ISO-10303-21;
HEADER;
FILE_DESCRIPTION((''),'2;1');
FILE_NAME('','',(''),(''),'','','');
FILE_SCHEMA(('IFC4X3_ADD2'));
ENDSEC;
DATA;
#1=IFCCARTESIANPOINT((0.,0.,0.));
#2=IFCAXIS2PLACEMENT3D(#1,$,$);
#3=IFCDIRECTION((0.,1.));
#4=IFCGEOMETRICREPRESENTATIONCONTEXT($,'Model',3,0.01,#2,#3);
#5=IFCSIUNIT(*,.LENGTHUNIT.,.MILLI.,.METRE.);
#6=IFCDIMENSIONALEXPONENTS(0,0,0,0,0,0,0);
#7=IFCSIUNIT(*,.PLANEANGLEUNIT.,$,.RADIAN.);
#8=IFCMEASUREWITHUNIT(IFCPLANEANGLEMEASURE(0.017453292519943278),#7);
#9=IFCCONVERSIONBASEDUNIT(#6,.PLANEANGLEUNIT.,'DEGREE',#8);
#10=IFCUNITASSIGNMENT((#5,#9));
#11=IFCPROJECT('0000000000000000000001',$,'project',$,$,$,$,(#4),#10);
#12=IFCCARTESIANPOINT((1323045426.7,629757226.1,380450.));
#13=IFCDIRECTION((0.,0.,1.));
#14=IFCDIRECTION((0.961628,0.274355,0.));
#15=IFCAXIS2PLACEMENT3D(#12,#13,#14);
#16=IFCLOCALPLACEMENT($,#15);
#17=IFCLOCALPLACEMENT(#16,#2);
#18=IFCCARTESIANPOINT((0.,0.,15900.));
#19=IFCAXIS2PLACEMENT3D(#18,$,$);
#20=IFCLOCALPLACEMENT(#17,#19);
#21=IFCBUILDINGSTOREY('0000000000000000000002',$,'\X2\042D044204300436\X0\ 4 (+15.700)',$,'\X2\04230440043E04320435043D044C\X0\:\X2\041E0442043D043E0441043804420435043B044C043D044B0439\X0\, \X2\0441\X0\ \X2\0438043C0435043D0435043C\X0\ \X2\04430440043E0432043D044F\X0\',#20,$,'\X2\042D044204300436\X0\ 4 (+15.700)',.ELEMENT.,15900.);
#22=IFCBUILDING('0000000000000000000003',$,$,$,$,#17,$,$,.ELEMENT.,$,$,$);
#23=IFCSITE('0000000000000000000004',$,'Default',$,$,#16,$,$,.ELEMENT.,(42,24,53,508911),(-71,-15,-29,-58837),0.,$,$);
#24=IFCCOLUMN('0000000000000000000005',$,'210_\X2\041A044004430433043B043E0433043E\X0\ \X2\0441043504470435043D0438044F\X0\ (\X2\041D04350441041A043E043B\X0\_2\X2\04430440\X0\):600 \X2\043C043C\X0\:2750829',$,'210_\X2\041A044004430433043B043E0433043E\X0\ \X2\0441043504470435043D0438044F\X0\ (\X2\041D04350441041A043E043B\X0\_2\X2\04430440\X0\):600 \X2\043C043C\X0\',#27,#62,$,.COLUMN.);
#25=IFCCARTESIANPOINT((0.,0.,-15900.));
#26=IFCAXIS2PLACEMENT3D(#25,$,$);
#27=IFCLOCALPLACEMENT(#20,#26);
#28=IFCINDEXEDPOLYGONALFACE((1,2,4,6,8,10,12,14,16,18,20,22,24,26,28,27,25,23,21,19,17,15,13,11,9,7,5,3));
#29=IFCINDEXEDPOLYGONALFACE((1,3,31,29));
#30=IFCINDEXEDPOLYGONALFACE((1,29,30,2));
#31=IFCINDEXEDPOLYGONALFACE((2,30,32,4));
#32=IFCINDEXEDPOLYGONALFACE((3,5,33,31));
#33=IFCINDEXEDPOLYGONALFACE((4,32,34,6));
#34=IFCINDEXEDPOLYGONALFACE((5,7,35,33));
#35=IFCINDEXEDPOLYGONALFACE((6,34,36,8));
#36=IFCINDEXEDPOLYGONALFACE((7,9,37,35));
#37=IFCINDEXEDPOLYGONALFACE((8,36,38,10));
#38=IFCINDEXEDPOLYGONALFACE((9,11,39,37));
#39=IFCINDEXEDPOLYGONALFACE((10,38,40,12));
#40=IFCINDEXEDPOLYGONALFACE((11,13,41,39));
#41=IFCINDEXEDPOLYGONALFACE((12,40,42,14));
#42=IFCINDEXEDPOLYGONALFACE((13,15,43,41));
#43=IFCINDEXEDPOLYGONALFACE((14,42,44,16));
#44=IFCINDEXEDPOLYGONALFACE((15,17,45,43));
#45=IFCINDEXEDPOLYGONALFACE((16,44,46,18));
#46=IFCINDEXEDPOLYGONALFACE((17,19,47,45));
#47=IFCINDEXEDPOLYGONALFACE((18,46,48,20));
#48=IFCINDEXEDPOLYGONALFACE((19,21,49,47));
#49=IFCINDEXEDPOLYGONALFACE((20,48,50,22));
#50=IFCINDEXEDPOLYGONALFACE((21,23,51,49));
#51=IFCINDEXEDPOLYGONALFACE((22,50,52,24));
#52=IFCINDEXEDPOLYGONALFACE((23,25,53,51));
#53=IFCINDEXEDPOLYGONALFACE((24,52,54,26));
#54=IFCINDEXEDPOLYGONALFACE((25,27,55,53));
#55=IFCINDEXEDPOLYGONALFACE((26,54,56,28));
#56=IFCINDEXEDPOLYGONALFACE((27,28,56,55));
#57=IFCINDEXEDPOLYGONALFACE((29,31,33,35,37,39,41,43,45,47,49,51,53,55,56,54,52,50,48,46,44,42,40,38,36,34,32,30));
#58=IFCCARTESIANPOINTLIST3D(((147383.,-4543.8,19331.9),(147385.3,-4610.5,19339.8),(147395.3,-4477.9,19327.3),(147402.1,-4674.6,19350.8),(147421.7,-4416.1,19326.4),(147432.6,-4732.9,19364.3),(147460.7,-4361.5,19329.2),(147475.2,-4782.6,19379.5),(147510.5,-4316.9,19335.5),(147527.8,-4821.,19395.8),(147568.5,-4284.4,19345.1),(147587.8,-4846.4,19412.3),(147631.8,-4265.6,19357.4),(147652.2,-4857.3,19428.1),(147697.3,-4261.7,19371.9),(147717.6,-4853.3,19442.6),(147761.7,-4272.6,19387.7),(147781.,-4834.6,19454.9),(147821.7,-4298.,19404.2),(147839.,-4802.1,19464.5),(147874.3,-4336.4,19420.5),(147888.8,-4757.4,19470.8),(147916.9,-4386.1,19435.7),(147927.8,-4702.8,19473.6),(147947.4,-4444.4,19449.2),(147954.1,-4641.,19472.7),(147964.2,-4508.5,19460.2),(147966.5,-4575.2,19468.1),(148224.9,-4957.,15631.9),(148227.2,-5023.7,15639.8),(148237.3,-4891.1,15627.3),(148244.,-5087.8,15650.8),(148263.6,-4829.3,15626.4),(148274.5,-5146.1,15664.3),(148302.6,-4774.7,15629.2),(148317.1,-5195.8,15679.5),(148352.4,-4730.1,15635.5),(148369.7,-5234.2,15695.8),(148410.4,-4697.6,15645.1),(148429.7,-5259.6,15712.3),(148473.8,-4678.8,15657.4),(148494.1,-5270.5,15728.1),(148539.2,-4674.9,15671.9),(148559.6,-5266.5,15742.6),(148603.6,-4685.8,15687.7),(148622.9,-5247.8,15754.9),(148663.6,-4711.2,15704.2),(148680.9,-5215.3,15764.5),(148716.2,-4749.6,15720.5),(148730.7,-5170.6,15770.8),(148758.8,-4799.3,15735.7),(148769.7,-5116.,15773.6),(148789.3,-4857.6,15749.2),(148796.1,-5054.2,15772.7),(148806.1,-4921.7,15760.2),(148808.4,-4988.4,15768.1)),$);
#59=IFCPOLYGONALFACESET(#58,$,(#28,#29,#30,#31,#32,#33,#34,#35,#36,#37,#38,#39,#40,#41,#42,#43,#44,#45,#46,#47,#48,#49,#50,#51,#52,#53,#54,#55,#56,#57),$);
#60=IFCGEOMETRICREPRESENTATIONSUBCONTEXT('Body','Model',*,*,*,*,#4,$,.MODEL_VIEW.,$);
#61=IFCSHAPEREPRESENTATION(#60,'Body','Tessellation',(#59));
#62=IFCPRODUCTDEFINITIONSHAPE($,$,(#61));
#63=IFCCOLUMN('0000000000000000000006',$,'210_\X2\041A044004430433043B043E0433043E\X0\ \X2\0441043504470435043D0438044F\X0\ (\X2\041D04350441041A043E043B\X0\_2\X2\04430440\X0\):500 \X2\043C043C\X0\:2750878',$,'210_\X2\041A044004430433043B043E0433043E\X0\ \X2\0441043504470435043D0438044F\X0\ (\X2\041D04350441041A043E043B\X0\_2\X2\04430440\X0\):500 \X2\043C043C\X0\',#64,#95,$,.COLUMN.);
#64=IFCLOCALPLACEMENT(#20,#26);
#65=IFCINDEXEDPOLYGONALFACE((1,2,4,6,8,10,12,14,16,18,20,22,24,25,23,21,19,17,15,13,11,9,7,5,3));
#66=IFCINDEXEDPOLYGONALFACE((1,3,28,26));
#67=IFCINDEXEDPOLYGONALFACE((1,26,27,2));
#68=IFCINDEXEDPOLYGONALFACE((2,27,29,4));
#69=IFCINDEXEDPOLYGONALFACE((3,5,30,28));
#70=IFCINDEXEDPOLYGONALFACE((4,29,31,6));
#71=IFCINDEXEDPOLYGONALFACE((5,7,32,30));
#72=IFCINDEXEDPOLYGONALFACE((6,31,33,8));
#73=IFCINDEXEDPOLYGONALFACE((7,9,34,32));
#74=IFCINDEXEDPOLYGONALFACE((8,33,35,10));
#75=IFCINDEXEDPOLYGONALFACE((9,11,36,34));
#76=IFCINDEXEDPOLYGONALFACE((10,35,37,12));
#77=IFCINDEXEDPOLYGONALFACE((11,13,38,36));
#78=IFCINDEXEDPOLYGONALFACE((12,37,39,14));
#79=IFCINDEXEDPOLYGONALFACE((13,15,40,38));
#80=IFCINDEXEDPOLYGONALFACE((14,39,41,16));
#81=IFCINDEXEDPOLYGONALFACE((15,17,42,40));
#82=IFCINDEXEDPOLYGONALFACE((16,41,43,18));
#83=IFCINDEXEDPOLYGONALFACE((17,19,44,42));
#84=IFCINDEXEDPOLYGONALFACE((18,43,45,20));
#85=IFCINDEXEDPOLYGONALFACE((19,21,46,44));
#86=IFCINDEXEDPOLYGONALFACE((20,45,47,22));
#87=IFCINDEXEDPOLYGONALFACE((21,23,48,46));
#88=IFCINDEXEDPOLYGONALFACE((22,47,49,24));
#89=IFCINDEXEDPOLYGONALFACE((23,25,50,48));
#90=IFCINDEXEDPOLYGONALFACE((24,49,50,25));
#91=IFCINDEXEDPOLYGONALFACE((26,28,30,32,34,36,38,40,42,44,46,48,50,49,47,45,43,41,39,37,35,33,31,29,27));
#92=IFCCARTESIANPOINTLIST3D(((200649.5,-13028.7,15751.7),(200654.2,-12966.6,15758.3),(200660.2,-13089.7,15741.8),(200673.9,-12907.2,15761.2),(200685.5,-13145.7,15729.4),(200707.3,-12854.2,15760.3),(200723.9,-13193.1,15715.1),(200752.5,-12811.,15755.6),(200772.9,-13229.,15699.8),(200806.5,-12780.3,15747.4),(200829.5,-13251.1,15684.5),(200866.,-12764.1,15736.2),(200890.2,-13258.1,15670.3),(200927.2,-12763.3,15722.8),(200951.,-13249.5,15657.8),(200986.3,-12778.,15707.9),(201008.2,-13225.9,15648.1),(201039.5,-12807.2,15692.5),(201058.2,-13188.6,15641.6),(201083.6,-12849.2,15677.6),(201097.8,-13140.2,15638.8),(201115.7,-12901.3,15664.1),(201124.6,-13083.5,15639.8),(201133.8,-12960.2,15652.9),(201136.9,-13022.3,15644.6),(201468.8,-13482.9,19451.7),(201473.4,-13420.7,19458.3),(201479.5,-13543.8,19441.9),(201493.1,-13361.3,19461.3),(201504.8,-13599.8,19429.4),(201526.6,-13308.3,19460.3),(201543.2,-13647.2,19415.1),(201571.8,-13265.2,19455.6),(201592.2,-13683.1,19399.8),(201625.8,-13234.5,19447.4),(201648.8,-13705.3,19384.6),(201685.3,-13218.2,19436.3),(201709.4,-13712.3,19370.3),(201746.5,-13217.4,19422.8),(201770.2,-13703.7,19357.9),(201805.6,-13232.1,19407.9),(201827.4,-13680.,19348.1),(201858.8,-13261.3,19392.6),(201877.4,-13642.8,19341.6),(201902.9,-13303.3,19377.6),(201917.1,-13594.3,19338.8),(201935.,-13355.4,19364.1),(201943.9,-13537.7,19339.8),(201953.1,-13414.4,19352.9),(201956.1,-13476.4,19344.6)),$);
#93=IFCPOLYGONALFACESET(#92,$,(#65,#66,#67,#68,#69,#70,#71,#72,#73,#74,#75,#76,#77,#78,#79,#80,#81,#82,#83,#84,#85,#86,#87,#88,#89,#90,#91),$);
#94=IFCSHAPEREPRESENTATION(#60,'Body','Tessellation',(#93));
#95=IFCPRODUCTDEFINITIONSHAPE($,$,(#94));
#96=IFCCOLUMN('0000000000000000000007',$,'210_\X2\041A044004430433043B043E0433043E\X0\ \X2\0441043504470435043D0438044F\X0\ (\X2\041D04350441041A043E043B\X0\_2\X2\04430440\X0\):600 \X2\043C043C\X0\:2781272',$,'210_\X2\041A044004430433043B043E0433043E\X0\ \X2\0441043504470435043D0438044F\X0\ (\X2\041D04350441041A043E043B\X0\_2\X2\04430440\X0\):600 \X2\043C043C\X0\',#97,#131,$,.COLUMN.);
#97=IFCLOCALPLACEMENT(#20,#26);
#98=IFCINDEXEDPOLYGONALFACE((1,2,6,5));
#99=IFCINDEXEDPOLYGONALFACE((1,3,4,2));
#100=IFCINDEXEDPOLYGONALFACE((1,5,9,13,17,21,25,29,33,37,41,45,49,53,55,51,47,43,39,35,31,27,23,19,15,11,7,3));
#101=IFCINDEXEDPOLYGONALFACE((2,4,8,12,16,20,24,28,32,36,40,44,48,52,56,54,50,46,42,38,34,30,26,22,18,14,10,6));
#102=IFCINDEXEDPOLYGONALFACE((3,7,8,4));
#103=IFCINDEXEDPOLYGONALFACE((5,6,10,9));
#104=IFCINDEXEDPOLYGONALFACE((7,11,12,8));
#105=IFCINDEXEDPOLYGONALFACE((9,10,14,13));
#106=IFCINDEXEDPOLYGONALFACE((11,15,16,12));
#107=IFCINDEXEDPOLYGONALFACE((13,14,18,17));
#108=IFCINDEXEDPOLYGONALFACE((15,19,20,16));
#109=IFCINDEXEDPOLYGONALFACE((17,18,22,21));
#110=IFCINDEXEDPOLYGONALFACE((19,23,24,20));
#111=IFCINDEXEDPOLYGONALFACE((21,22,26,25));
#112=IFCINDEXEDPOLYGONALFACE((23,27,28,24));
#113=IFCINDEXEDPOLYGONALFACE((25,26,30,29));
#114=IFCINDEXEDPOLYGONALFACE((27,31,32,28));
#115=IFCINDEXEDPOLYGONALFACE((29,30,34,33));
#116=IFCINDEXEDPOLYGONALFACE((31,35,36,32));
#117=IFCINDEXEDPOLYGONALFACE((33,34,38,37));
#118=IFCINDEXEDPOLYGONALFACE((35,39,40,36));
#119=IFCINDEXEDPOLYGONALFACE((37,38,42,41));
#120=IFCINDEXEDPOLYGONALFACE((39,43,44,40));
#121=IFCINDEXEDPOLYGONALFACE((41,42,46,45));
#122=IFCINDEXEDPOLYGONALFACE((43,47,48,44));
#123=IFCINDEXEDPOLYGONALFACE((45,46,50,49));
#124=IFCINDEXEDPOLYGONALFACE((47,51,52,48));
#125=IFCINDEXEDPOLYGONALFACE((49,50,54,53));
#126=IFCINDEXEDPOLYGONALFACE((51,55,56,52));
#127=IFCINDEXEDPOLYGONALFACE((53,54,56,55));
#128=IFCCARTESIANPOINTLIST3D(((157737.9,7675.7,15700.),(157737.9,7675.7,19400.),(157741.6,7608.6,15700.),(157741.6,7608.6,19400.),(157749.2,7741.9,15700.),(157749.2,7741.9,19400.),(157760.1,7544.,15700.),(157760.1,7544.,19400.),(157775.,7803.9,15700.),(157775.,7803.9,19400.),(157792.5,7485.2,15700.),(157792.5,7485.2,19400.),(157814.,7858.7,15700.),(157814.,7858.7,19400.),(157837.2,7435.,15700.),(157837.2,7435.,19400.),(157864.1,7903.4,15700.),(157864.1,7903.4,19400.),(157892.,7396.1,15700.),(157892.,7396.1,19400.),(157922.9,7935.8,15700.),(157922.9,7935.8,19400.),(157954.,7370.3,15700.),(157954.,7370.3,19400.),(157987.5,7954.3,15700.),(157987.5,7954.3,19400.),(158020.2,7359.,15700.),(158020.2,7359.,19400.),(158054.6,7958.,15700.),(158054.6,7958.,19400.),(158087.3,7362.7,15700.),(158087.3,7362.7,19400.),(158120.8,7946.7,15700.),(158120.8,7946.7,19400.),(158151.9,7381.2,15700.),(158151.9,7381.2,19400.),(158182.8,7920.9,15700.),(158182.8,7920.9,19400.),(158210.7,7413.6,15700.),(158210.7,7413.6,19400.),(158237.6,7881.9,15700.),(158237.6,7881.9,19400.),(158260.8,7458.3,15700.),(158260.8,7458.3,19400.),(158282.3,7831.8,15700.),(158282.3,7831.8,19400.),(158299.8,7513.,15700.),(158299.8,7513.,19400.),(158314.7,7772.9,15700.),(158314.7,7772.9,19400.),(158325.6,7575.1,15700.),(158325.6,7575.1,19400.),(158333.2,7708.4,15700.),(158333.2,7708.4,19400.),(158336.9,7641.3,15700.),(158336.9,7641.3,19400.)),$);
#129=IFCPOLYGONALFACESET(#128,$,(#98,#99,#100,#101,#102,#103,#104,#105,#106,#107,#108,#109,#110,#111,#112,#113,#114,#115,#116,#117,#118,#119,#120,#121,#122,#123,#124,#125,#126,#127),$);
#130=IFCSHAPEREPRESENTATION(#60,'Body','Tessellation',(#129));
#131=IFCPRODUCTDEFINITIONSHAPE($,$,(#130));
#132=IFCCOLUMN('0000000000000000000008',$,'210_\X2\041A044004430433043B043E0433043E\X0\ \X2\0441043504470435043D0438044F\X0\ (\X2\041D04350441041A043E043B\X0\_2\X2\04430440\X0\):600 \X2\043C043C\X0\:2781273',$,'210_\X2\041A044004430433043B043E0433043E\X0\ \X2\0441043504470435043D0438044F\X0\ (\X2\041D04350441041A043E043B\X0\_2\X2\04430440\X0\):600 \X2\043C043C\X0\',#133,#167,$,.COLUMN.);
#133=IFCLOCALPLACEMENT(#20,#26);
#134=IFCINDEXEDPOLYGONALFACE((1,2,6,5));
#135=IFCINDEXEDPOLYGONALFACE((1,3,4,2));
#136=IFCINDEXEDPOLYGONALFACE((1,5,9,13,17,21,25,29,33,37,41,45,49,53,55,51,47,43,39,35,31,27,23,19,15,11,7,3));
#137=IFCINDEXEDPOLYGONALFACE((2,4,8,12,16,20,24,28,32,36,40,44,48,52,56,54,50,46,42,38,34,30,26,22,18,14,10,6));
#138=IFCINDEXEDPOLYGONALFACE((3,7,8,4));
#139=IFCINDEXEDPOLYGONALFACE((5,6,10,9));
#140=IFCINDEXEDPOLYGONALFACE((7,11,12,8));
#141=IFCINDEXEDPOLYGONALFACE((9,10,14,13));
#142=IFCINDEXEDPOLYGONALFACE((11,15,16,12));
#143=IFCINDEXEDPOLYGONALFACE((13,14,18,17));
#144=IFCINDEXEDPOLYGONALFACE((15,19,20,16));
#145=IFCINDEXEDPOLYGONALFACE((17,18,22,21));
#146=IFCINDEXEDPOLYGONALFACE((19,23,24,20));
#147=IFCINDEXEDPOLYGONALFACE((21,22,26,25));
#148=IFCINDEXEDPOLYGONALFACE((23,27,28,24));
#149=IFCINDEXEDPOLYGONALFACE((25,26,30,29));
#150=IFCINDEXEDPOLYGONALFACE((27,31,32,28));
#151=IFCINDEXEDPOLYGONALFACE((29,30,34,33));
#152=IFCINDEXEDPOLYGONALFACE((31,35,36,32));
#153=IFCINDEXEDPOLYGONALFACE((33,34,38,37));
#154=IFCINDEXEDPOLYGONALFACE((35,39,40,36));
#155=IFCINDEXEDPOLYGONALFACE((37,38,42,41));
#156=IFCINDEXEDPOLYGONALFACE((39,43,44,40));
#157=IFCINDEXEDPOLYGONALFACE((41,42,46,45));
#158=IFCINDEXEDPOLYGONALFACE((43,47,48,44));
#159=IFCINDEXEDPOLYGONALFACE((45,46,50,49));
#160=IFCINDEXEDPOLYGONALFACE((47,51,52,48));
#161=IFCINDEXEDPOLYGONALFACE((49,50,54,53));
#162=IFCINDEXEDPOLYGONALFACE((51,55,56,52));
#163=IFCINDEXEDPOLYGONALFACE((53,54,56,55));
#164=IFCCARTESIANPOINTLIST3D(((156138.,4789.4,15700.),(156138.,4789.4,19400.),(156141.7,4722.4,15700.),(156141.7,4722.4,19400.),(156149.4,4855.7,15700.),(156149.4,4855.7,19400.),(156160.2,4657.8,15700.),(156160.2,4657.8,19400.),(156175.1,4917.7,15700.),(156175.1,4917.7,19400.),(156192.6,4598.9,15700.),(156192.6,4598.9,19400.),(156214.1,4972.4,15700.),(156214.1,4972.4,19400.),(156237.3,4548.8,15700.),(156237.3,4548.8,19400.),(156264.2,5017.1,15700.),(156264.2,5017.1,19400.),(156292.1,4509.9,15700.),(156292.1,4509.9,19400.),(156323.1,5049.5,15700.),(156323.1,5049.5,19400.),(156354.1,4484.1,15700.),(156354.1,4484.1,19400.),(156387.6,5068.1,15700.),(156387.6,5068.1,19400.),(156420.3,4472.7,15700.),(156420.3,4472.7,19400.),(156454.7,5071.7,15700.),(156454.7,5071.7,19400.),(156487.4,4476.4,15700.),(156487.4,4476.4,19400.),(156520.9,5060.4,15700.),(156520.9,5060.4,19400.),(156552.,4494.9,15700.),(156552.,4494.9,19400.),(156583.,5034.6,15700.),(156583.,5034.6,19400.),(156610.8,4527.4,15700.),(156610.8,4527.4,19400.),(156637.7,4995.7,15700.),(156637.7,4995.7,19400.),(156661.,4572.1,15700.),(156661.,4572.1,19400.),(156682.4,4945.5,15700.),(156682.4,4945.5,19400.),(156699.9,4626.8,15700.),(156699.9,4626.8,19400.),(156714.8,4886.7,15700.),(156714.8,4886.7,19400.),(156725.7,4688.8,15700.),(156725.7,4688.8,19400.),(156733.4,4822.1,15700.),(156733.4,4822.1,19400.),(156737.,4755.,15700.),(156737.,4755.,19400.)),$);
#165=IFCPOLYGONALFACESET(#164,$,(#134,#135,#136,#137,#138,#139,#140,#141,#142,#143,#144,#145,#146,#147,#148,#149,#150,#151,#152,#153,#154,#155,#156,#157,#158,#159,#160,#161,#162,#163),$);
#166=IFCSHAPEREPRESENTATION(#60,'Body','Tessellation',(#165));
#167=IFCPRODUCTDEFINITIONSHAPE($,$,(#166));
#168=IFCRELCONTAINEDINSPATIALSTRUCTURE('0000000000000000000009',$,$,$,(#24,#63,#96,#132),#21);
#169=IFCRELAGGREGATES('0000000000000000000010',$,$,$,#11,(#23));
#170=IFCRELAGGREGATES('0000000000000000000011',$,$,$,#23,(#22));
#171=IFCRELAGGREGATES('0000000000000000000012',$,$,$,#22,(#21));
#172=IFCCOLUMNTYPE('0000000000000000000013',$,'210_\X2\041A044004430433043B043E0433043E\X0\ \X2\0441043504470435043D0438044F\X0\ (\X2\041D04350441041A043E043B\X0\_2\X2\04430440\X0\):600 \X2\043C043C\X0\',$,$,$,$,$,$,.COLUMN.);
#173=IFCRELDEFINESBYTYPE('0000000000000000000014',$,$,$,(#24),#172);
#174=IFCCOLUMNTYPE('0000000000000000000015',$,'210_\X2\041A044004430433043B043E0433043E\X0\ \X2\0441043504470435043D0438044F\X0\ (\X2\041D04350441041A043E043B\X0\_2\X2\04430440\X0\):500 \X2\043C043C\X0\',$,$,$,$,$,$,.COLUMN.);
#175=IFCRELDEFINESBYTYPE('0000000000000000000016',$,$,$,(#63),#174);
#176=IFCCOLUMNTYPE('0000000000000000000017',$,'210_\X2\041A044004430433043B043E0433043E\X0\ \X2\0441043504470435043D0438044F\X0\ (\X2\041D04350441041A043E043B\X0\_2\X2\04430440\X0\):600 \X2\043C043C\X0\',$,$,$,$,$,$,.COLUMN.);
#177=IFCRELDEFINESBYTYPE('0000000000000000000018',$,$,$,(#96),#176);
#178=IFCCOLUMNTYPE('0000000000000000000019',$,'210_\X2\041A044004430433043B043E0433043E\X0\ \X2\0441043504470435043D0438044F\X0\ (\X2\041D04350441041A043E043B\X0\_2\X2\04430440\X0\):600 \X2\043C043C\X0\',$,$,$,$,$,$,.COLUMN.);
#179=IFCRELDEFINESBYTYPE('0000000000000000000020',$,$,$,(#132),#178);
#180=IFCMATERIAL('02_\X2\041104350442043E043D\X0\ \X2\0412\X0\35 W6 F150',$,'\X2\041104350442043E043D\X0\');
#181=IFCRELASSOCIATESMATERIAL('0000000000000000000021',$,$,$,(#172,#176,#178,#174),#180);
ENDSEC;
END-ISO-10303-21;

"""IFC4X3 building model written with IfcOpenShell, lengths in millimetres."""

from ifc_helpers import new_model, entity, si_unit, converted_unit, direction, frame, frame_2d, origin, origin_2d_with_axis, place, context, subcontext, project, spatial, circle, extrude, source, transform, mapped, material, material_profile, profile_set, type_object, type_shapes, element, save


model = new_model("IFC4X3")

# Units and contexts
model_context = context("Model", 3, precision=0.01, world=origin(), true_north=direction((0.0, 1.0)))
body_context = subcontext(model_context, "Body", "Model", "MODEL_VIEW")
ifc_project = project(units=[si_unit("LENGTHUNIT", "METRE", prefix="MILLI"), converted_unit("PLANEANGLEUNIT", "DEGREE", entity("IfcPlaneAngleMeasure", 0.017453292519943278), si_unit("PLANEANGLEUNIT", "RADIAN"), dimensions=[0, 0, 0, 0, 0, 0, 0])], contexts=[model_context])

# Site, building, storey
site_placement = place(None, frame((1323045426.7, 629757226.1, 380450.0), z_axis=(0.0, 0.0, 1.0), x_axis=(0.961628, 0.274355, 0.0)))
site = spatial("IfcSite", under=ifc_project, at=site_placement, Name="Default", CompositionType="ELEMENT", RefLatitude=(42, 24, 53, 508911), RefLongitude=(-71, -15, -29, -58837), RefElevation=0.0)
building_placement = place(site_placement, origin())
building = spatial("IfcBuilding", under=site, at=building_placement, CompositionType="ELEMENT")
storey_placement = place(building_placement, frame((0.0, 0.0, 15900.0)))
storey = spatial("IfcBuildingStorey", under=building, at=storey_placement, Name="Этаж 4 (+15.700)", ObjectType="Уровень:Относительный, с именем уровня", LongName="Этаж 4 (+15.700)", CompositionType="ELEMENT", Elevation=15900.0)

# Columns
ifc_material = material(Name="02_Бетон В35 W6 F150", Category="Бетон")
ifc_material_profile_1 = material_profile(ifc_material, circle(Radius=300.0, at=frame_2d((0.0, 0.0), x_axis=(1.0, 0.0))), Name="600 мм")
ifc_profile_set_1 = profile_set([ifc_material_profile_1], Name="600 мм")
column_type_1 = type_object("IfcColumnType", Name="210_Круглого сечения (НесКол_2ур):600 мм", PredefinedType="COLUMN", material=ifc_profile_set_1)
shared_shape_1 = source(origin(), body_context, "Body", "SweptSolid", [
    extrude(circle(Radius=300.0, at=frame_2d((0.0, 0.0), x_axis=(1.0, 0.0))), frame((148516.7, -4972.7, 15700.0), z_axis=(-0.220572, 0.108251, 0.969345), x_axis=(-0.807217, -0.578111, -0.11912)), (0.0, 0.0, 1.0), 3817.0),
])
type_shapes(column_type_1, [shared_shape_1])
column_1_placement = place(storey_placement, frame((0.0, 0.0, -15900.0)))
element("IfcColumn", 1, at=column_1_placement, inside=storey, type_object=column_type_1, Name="210_Круглого сечения (НесКол_2ур):600 мм:2750829", ObjectType="210_Круглого сечения (НесКол_2ур):600 мм", PredefinedType="COLUMN", context=body_context, shape_type="MappedRepresentation", body=[
    mapped(shared_shape_1, transform((0.0, 0.0, 0.0), scale=1.0)),
])
ifc_material_profile_2 = material_profile(ifc_material, circle(Radius=250.0, at=origin_2d_with_axis()), Name="500 мм")
ifc_profile_set_2 = profile_set([ifc_material_profile_2], Name="500 мм")
column_type_2 = type_object("IfcColumnType", Name="210_Круглого сечения (НесКол_2ур):500 мм", PredefinedType="COLUMN", material=ifc_profile_set_2)
shared_shape_2 = source(origin(), body_context, "Body", "SweptSolid", [
    extrude(circle(Radius=250.0, at=origin_2d_with_axis()), frame((200893.4, -13009.9, 15700.0), z_axis=(0.214651, -0.118983, 0.969416), x_axis=(-0.012968, -0.992812, -0.118983)), (0.0, 0.0, 1.0), 3816.8),
])
type_shapes(column_type_2, [shared_shape_2])
column_2_placement = place(storey_placement, frame((0.0, 0.0, -15900.0)))
element("IfcColumn", 2, at=column_2_placement, inside=storey, type_object=column_type_2, Name="210_Круглого сечения (НесКол_2ур):500 мм:2750878", ObjectType="210_Круглого сечения (НесКол_2ур):500 мм", PredefinedType="COLUMN", context=body_context, shape_type="MappedRepresentation", body=[
    mapped(shared_shape_2, transform((0.0, 0.0, 0.0), scale=1.0)),
])
column_type_3 = type_object("IfcColumnType", Name="210_Круглого сечения (НесКол_2ур):600 мм", PredefinedType="COLUMN", material=ifc_profile_set_1)
shared_shape_3 = source(origin(), body_context, "Body", "SweptSolid", [
    extrude(circle(Radius=300.0, at=frame_2d((0.0, 0.0), x_axis=(1.0, 0.0))), frame((158037.4, 7658.5, 15700.0), z_axis=(0.0, 0.0, 1.0), x_axis=(0.87462, -0.48481, 0.0)), (0.0, 0.0, 1.0), 3700.0),
])
type_shapes(column_type_3, [shared_shape_3])
column_3_placement = place(storey_placement, frame((0.0, 0.0, -15900.0)))
element("IfcColumn", 3, at=column_3_placement, inside=storey, type_object=column_type_3, Name="210_Круглого сечения (НесКол_2ур):600 мм:2781272", ObjectType="210_Круглого сечения (НесКол_2ур):600 мм", PredefinedType="COLUMN", context=body_context, shape_type="MappedRepresentation", body=[
    mapped(shared_shape_3, transform((0.0, 0.0, 0.0), scale=1.0)),
])
column_type_4 = type_object("IfcColumnType", Name="210_Круглого сечения (НесКол_2ур):600 мм", PredefinedType="COLUMN", material=ifc_profile_set_1)
shared_shape_4 = source(origin(), body_context, "Body", "SweptSolid", [
    extrude(circle(Radius=300.0, at=frame_2d((0.0, 0.0), x_axis=(1.0, 0.0))), frame((156437.5, 4772.2, 15700.0), z_axis=(0.0, 0.0, 1.0), x_axis=(0.87462, -0.48481, 0.0)), (0.0, 0.0, 1.0), 3700.0),
])
type_shapes(column_type_4, [shared_shape_4])
column_4_placement = place(storey_placement, frame((0.0, 0.0, -15900.0)))
element("IfcColumn", 4, at=column_4_placement, inside=storey, type_object=column_type_4, Name="210_Круглого сечения (НесКол_2ур):600 мм:2781273", ObjectType="210_Круглого сечения (НесКол_2ур):600 мм", PredefinedType="COLUMN", context=body_context, shape_type="MappedRepresentation", body=[
    mapped(shared_shape_4, transform((0.0, 0.0, 0.0), scale=1.0)),
])

save(model, "model.ifc")
